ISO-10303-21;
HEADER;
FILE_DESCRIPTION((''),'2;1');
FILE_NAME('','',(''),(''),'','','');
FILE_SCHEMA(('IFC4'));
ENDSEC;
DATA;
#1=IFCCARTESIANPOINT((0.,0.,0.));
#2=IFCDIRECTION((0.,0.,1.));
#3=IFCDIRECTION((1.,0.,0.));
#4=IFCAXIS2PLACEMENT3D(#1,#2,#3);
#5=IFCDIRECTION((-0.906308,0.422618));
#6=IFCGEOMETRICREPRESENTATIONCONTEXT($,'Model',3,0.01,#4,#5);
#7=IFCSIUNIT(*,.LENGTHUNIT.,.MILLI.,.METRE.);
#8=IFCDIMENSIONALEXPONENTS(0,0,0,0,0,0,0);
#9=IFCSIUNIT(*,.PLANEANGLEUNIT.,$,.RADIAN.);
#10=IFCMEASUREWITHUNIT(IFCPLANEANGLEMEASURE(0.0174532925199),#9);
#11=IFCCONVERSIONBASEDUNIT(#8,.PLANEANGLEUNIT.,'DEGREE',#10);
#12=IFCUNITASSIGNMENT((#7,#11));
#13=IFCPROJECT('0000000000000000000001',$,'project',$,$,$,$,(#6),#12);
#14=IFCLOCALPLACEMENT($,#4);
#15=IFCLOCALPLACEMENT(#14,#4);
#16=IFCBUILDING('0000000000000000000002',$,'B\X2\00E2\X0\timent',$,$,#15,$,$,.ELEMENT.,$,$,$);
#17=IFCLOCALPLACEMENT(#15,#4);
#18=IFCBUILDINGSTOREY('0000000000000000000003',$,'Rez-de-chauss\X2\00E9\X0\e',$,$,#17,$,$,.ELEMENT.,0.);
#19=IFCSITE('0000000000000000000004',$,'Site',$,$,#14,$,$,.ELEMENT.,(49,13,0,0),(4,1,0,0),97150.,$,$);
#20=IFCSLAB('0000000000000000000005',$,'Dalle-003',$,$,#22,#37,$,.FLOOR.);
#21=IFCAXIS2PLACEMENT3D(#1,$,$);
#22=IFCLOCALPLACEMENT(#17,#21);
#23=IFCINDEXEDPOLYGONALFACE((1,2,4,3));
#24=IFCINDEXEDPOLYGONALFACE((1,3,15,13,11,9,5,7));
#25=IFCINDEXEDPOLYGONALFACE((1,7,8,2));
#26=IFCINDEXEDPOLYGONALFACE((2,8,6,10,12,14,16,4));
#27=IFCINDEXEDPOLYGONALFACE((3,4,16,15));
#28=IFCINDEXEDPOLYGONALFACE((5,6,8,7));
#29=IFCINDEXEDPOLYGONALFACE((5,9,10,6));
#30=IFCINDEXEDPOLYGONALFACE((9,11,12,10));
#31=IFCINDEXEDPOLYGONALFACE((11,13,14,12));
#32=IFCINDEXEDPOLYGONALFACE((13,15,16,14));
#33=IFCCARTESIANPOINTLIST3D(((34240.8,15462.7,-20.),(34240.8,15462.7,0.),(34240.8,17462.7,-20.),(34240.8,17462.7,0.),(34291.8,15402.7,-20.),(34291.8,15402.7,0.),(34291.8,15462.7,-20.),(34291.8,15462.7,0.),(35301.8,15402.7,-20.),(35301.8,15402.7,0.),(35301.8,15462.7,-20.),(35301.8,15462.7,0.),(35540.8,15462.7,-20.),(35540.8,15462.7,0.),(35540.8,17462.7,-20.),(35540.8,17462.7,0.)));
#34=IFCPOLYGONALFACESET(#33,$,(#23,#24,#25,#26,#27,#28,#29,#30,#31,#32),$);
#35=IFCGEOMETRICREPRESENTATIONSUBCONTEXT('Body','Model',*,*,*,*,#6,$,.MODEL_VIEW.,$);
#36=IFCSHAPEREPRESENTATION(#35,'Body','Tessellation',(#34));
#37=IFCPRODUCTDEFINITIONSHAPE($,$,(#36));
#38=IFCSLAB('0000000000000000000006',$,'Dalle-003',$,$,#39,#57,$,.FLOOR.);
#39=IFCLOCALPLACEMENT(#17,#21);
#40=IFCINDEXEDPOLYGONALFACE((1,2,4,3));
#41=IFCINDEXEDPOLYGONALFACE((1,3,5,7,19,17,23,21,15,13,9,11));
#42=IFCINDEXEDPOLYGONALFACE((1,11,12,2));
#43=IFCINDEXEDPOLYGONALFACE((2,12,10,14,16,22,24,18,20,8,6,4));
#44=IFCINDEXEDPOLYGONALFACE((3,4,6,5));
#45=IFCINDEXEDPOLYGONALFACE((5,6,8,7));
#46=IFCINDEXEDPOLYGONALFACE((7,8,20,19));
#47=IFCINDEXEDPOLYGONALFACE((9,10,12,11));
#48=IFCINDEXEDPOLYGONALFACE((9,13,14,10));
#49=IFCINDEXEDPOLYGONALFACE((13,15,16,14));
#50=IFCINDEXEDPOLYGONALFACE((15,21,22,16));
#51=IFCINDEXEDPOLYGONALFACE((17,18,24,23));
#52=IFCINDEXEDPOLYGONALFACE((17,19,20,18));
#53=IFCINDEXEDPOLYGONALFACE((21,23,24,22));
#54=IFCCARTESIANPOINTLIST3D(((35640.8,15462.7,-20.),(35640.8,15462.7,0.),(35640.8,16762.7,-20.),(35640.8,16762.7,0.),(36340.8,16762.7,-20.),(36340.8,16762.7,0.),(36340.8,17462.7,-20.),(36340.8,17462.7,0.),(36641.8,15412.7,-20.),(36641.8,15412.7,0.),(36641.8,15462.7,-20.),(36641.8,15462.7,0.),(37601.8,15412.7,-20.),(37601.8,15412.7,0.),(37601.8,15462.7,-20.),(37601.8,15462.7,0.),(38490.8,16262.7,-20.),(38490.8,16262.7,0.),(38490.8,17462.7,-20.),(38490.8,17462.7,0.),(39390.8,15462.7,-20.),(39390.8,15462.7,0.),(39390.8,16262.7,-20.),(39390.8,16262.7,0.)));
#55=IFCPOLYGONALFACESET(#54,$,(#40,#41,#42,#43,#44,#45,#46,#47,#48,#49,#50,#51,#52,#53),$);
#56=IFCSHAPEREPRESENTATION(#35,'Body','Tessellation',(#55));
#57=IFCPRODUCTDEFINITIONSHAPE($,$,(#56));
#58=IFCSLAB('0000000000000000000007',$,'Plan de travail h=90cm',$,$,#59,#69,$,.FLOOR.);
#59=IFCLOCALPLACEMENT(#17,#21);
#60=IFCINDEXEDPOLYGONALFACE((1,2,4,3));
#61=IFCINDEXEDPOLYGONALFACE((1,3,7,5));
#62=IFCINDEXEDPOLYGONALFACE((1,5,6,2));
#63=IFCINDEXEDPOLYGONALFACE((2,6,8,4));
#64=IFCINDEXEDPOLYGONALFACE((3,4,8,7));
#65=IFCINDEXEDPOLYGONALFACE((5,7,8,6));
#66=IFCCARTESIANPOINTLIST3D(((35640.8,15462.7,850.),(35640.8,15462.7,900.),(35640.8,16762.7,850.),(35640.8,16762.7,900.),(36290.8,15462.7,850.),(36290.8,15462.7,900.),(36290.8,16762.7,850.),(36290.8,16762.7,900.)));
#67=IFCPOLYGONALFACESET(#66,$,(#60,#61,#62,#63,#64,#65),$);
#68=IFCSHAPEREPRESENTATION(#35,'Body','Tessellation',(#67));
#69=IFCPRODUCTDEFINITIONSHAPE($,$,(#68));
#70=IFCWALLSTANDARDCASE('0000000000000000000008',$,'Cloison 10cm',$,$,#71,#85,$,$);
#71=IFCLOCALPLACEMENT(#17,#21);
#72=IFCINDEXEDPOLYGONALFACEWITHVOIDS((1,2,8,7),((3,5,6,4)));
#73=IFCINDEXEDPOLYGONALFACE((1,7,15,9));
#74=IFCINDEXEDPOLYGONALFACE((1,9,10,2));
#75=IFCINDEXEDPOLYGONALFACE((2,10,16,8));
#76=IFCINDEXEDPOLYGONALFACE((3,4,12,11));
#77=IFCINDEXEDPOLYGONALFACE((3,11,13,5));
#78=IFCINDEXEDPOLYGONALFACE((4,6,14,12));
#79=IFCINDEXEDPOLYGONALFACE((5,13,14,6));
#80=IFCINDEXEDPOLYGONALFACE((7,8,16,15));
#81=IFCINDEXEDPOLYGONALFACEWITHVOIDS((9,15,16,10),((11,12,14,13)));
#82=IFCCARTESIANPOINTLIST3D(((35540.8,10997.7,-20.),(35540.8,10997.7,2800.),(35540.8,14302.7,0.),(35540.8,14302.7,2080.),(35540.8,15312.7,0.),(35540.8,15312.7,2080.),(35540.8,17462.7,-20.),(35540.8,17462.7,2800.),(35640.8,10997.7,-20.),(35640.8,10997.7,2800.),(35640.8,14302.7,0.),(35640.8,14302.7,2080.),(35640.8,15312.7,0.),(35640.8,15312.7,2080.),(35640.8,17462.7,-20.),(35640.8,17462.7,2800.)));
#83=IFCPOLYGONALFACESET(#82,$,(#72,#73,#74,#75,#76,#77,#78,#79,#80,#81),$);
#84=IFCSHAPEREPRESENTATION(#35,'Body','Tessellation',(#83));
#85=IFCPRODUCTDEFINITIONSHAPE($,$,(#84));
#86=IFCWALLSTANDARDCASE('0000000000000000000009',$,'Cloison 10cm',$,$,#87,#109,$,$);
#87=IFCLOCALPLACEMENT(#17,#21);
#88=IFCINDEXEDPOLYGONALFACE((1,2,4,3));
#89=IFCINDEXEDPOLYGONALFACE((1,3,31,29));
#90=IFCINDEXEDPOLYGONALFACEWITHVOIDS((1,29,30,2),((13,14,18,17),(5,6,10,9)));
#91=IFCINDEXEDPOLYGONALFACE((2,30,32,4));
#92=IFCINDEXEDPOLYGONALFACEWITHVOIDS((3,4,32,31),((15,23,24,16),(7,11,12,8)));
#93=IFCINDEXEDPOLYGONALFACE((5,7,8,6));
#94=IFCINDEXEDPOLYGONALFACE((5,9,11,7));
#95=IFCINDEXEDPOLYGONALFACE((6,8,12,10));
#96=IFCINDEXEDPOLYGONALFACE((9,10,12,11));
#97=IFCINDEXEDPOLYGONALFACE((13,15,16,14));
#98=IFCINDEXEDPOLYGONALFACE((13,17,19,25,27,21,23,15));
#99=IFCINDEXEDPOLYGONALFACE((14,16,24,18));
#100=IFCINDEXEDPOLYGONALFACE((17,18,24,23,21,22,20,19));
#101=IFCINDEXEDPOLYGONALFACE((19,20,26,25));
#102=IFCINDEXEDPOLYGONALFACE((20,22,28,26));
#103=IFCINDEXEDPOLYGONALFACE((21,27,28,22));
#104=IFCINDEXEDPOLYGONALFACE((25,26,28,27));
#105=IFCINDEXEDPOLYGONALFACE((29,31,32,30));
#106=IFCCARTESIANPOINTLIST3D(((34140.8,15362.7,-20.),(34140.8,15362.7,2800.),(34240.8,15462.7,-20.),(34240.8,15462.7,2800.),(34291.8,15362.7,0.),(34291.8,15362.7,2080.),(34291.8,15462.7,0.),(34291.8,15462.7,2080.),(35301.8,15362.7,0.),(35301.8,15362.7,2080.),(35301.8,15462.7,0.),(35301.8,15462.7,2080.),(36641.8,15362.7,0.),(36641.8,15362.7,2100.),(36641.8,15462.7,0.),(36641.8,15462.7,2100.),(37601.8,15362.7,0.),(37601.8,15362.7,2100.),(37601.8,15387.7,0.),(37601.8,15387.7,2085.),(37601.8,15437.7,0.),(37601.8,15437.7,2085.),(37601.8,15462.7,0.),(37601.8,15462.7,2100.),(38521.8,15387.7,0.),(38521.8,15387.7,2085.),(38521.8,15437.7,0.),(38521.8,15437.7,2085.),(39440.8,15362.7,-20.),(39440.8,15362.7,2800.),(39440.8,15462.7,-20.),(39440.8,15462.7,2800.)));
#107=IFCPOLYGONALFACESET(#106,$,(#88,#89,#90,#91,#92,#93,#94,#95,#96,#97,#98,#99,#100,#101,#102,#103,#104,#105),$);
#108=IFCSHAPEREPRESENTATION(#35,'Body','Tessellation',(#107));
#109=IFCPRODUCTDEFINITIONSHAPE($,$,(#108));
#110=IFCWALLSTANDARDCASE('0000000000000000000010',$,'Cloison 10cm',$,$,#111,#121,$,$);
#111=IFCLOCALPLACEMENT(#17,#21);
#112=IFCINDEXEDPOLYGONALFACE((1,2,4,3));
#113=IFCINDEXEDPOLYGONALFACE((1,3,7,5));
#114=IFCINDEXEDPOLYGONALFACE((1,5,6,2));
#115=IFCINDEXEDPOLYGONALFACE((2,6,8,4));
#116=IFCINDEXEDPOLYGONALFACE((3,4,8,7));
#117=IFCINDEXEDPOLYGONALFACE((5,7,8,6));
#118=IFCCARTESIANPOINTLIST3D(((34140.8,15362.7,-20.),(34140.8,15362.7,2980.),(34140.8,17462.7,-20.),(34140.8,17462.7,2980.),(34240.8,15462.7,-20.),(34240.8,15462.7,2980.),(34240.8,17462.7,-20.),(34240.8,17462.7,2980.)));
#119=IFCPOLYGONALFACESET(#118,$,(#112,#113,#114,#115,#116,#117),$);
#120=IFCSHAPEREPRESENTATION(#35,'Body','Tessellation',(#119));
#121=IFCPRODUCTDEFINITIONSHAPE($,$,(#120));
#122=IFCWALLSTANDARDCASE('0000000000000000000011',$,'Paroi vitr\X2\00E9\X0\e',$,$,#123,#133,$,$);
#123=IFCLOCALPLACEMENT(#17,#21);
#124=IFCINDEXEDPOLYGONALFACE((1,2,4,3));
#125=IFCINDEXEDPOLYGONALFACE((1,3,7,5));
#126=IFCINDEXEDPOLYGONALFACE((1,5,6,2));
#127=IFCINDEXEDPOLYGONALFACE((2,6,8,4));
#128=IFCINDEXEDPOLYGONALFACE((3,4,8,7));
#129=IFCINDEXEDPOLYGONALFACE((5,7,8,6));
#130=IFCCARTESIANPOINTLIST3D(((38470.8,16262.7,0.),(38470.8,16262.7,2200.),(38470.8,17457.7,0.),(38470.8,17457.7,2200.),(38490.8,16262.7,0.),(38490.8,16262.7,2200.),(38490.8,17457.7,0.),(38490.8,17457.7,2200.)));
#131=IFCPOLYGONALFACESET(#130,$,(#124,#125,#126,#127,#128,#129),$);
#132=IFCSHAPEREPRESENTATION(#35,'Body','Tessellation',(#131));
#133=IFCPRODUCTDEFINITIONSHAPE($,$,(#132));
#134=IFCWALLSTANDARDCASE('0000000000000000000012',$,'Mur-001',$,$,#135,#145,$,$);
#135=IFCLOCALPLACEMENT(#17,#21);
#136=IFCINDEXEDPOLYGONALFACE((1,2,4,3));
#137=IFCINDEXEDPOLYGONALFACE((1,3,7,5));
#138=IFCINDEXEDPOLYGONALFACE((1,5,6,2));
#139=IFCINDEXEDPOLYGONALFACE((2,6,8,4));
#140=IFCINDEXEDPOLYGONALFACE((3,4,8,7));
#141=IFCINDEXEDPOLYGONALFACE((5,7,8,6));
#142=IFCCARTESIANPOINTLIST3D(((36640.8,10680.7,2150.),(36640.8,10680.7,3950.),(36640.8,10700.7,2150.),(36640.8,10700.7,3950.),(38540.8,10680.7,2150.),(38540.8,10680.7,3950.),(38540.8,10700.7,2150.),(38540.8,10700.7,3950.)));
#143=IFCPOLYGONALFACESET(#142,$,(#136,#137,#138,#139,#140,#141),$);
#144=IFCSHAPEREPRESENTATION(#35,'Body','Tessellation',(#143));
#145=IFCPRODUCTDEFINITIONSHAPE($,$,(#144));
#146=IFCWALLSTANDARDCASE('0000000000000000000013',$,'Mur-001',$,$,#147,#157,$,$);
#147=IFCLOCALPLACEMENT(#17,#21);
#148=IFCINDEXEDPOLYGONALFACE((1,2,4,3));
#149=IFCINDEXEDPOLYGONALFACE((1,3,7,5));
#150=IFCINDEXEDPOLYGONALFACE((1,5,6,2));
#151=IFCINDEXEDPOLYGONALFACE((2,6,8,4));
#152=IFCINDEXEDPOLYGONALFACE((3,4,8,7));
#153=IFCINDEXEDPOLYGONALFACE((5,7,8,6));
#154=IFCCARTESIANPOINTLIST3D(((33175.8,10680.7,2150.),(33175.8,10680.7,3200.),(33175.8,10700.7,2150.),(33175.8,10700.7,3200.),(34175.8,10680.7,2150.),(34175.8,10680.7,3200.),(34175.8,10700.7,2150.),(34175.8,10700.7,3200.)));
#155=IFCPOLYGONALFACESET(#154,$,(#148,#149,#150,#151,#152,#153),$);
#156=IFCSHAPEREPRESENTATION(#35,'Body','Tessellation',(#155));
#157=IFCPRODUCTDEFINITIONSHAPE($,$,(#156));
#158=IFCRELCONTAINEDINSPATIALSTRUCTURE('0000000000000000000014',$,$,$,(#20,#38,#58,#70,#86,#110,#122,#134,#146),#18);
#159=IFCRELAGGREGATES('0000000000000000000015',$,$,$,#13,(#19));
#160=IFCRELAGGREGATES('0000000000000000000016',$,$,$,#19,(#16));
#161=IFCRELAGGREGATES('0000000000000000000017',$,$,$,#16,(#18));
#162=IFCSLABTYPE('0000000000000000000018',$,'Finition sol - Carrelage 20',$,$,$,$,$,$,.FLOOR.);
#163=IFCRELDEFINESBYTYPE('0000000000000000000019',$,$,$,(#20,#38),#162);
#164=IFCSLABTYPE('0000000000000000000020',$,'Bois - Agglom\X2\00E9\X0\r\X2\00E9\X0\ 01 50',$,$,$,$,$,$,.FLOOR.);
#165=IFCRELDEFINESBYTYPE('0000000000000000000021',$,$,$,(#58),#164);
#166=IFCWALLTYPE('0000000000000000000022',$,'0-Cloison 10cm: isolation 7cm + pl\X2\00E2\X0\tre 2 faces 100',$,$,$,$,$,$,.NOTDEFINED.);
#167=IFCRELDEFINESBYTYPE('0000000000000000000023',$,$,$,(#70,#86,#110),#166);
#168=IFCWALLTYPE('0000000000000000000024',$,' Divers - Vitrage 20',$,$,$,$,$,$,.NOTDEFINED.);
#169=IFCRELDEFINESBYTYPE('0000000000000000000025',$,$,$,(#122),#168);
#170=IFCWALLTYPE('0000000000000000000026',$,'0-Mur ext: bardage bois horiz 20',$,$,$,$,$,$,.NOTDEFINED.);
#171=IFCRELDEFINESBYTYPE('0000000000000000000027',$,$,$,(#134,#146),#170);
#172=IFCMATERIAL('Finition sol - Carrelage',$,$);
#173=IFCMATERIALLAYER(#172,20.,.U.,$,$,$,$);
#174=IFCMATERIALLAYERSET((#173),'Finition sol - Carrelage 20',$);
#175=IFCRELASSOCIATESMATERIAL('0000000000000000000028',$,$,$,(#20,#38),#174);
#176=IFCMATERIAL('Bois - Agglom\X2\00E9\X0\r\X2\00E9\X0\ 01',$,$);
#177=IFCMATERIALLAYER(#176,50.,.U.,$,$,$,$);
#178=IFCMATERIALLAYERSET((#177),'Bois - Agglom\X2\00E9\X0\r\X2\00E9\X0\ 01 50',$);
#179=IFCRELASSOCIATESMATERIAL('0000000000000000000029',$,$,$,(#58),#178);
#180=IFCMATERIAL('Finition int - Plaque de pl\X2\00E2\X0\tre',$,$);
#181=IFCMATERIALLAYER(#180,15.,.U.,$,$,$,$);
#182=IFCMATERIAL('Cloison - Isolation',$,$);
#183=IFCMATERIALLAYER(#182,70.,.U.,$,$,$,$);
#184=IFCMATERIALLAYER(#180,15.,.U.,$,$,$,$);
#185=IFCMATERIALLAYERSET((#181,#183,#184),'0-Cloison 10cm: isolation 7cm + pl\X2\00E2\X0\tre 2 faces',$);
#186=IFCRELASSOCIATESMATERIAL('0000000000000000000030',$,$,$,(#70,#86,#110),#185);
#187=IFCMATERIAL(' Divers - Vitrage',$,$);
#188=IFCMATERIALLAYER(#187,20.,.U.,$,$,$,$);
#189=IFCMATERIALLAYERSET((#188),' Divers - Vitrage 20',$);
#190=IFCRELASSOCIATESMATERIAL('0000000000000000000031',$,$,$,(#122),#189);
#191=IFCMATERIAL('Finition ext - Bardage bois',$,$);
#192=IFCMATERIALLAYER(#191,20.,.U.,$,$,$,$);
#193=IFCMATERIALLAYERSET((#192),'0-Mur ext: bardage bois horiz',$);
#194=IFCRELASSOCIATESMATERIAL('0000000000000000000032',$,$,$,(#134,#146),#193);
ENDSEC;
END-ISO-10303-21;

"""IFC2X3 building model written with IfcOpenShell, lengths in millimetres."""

from ifc_helpers import new_model, entity, si_unit, converted_unit, direction, frame, origin_with_axes, origin_2d_with_axis, place, context, subcontext, project, spatial, polyline, rectangle, outline, extrude, material, layer, layer_set, layer_usage, type_object, element, save


model = new_model("IFC2X3")

# Units and contexts
model_context = context("Model", 3, precision=0.01, world=origin_with_axes(), true_north=direction((-0.906308, 0.422618)))
body_context = subcontext(model_context, "Body", "Model", "MODEL_VIEW")
ifc_project = project(units=[si_unit("LENGTHUNIT", "METRE", prefix="MILLI"), converted_unit("PLANEANGLEUNIT", "DEGREE", entity("IfcPlaneAngleMeasure", 0.0174532925199), si_unit("PLANEANGLEUNIT", "RADIAN"), dimensions=[0, 0, 0, 0, 0, 0, 0])], contexts=[model_context])

# Site, building, storey
site_placement = place(None, origin_with_axes())
site = spatial("IfcSite", under=ifc_project, at=site_placement, Name="Site", CompositionType="ELEMENT", RefLatitude=(49, 13, 0, 0), RefLongitude=(4, 1, 0, 0), RefElevation=97150.0)
building_placement = place(site_placement, origin_with_axes())
building = spatial("IfcBuilding", under=site, at=building_placement, Name="Bâtiment", CompositionType="ELEMENT")
storey_placement = place(building_placement, origin_with_axes())
storey = spatial("IfcBuildingStorey", under=building, at=storey_placement, Name="Rez-de-chaussée", CompositionType="ELEMENT", Elevation=0.0)

# Slabs
ifc_material_1 = material(Name="Finition sol - Carrelage")
ifc_layer_1 = layer(ifc_material_1, 20.0, ventilated="UNKNOWN")
ifc_layer_set_1 = layer_set([ifc_layer_1], Name="Finition sol - Carrelage 20")
ifc_layer_usage_1 = layer_usage(ifc_layer_set_1, "AXIS3", "NEGATIVE", 20.0)
slab_type_1 = type_object("IfcSlabType", Name="Finition sol - Carrelage 20", PredefinedType="FLOOR")
slab_1_placement = place(storey_placement, frame((34240.8, 15462.7, 0.0), z_axis=(0.0, 0.0, 1.0), x_axis=(1.0, 0.0, 0.0)))
element("IfcSlab", 1, at=slab_1_placement, inside=storey, type_object=slab_type_1, material=ifc_layer_usage_1, Name="Dalle-003", PredefinedType="FLOOR", context=body_context, shape_type="SweptSolid", body=[
    extrude(outline(polyline([(0.0, 0.0), (51.0, 0.0), (51.0, -60.0), (1061.0, -60.0), (1061.0, 0.0), (1300.0, 0.0), (1300.0, 2000.0), (0.0, 2000.0), (0.0, 0.0)])), frame((0.0, 0.0, -20.0), z_axis=(0.0, 0.0, 1.0), x_axis=(1.0, 0.0, 0.0)), (0.0, 0.0, 1.0), 20.0),
])
ifc_layer_usage_2 = layer_usage(ifc_layer_set_1, "AXIS3", "NEGATIVE", 20.0)
slab_2_placement = place(storey_placement, frame((35640.8, 15462.7, 0.0), z_axis=(0.0, 0.0, 1.0), x_axis=(1.0, 0.0, 0.0)))
element("IfcSlab", 2, at=slab_2_placement, inside=storey, type_object=slab_type_1, material=ifc_layer_usage_2, Name="Dalle-003", PredefinedType="FLOOR", context=body_context, shape_type="SweptSolid", body=[
    extrude(outline(polyline([(0.0, 0.0), (1001.0, 0.0), (1001.0, -50.0), (1961.0, -50.0), (1961.0, 0.0), (3750.0, 0.0), (3750.0, 800.0), (2850.0, 800.0), (2850.0, 2000.0), (700.0, 2000.0), (700.0, 1300.0), (0.0, 1300.0), (0.0, 0.0)])), frame((0.0, 0.0, -20.0), z_axis=(0.0, 0.0, 1.0), x_axis=(1.0, 0.0, 0.0)), (0.0, 0.0, 1.0), 20.0),
])
ifc_material_2 = material(Name="Bois - Aggloméré 01")
ifc_layer_2 = layer(ifc_material_2, 50.0, ventilated="UNKNOWN")
ifc_layer_set_2 = layer_set([ifc_layer_2], Name="Bois - Aggloméré 01 50")
ifc_layer_usage_3 = layer_usage(ifc_layer_set_2, "AXIS3", "NEGATIVE", 50.0)
slab_type_2 = type_object("IfcSlabType", Name="Bois - Aggloméré 01 50", PredefinedType="FLOOR")
slab_3_placement = place(storey_placement, frame((35640.8, 15462.7, 900.0), z_axis=(0.0, 0.0, 1.0), x_axis=(1.0, 0.0, 0.0)))
element("IfcSlab", 3, at=slab_3_placement, inside=storey, type_object=slab_type_2, material=ifc_layer_usage_3, Name="Plan de travail h=90cm", PredefinedType="FLOOR", context=body_context, shape_type="SweptSolid", body=[
    extrude(outline(polyline([(0.0, 0.0), (650.0, 0.0), (650.0, 1300.0), (0.0, 1300.0), (0.0, 0.0)])), frame((0.0, 0.0, -50.0), z_axis=(0.0, 0.0, 1.0), x_axis=(1.0, 0.0, 0.0)), (0.0, 0.0, 1.0), 50.0),
])

# Wall, opening
ifc_material_3 = material(Name="Finition int - Plaque de plâtre")
ifc_layer_3 = layer(ifc_material_3, 15.0, ventilated="UNKNOWN")
ifc_material_4 = material(Name="Cloison - Isolation")
ifc_layer_4 = layer(ifc_material_4, 70.0, ventilated="UNKNOWN")
ifc_layer_5 = layer(ifc_material_3, 15.0, ventilated="UNKNOWN")
ifc_layer_set_3 = layer_set([ifc_layer_3, ifc_layer_4, ifc_layer_5], Name="0-Cloison 10cm: isolation 7cm + plâtre 2 faces")
ifc_layer_usage_4 = layer_usage(ifc_layer_set_3, "AXIS2", "POSITIVE", 0.0)
wall_type_1 = type_object("IfcWallType", Name="0-Cloison 10cm: isolation 7cm + plâtre 2 faces 100", PredefinedType="NOTDEFINED")
wall_1_placement = place(storey_placement, frame((35540.8, 17462.7, -20.0), z_axis=(0.0, 0.0, 1.0), x_axis=(0.0, -1.0, 0.0)))
wall_1 = element("IfcWallStandardCase", 4, at=wall_1_placement, inside=storey, type_object=wall_type_1, material=ifc_layer_usage_4, Name="Cloison 10cm", context=body_context, shape_type="SweptSolid", body=[
    extrude(outline(polyline([(0.0, 0.0), (6465.0, 0.0), (6465.0, 100.0), (0.0, 100.0), (0.0, 0.0)])), origin_with_axes(), (0.0, 0.0, 1.0), 2820.0),
])
opening_1_placement = place(wall_1_placement, frame((2655.0, 0.0, 20.0), z_axis=(0.0, 0.0, 1.0), x_axis=(1.0, 0.0, 0.0)))
element("IfcOpeningElement", 5, at=opening_1_placement, cuts=wall_1, context=body_context, shape_type="SweptSolid", body=[
    extrude(rectangle(XDim=1010.0, YDim=2080.0, at=origin_2d_with_axis()), frame((0.0, -100.0, 1040.0), z_axis=(0.0, -1.0, 0.0), x_axis=(-1.0, 0.0, 0.0)), (0.0, 0.0, -1.0), 300.0),
])

# Wall, openings
ifc_layer_usage_5 = layer_usage(ifc_layer_set_3, "AXIS2", "POSITIVE", 0.0)
wall_2_placement = place(storey_placement, frame((34140.8, 15362.7, -20.0), z_axis=(0.0, 0.0, 1.0), x_axis=(1.0, 0.0, 0.0)))
wall_2 = element("IfcWallStandardCase", 6, at=wall_2_placement, inside=storey, type_object=wall_type_1, material=ifc_layer_usage_5, Name="Cloison 10cm", context=body_context, shape_type="SweptSolid", body=[
    extrude(outline(polyline([(0.0, 0.0), (5300.0, 0.0), (5300.0, 100.0), (100.0, 100.0), (0.0, 0.0)])), origin_with_axes(), (0.0, 0.0, 1.0), 2820.0),
])
opening_2_placement = place(wall_2_placement, frame((2981.0, 0.0, 20.0), z_axis=(0.0, 0.0, 1.0), x_axis=(1.0, 0.0, 0.0)))
element("IfcOpeningElement", 7, at=opening_2_placement, cuts=wall_2, context=body_context, shape_type="SweptSolid", body=[
    extrude(rectangle(XDim=960.0, YDim=2100.0, at=origin_2d_with_axis()), frame((0.0, -100.0, 1050.0), z_axis=(0.0, 1.0, 0.0), x_axis=(1.0, 0.0, 0.0)), (0.0, 0.0, 1.0), 300.0),
    extrude(outline(polyline([(1400.0, 0.0), (1400.0, 2085.0), (480.0, 2085.0), (480.0, 0.0), (1400.0, 0.0)])), frame((0.0, 75.0, 0.0), z_axis=(0.0, -1.0, 0.0), x_axis=(1.0, 0.0, 0.0)), (0.0, 0.0, 1.0), 50.0),
])
opening_3_placement = place(wall_2_placement, frame((656.0, 0.0, 20.0), z_axis=(0.0, 0.0, 1.0), x_axis=(1.0, 0.0, 0.0)))
element("IfcOpeningElement", 8, at=opening_3_placement, cuts=wall_2, context=body_context, shape_type="SweptSolid", body=[
    extrude(rectangle(XDim=1010.0, YDim=2080.0, at=origin_2d_with_axis()), frame((0.0, 100.0, 1040.0), z_axis=(0.0, 1.0, 0.0), x_axis=(1.0, 0.0, 0.0)), (0.0, 0.0, -1.0), 300.0),
])

# Walls
ifc_layer_usage_6 = layer_usage(ifc_layer_set_3, "AXIS2", "POSITIVE", -100.0)
wall_3_placement = place(storey_placement, frame((34140.8, 15362.7, -20.0), z_axis=(0.0, 0.0, 1.0), x_axis=(0.0, 1.0, 0.0)))
element("IfcWallStandardCase", 9, at=wall_3_placement, inside=storey, type_object=wall_type_1, material=ifc_layer_usage_6, Name="Cloison 10cm", context=body_context, shape_type="SweptSolid", body=[
    extrude(outline(polyline([(100.0, -100.0), (2100.0, -100.0), (2100.0, 0.0), (0.0, 0.0), (100.0, -100.0)])), origin_with_axes(), (0.0, 0.0, 1.0), 3000.0),
])
ifc_material_5 = material(Name=" Divers - Vitrage")
ifc_layer_6 = layer(ifc_material_5, 20.0, ventilated="UNKNOWN")
ifc_layer_set_4 = layer_set([ifc_layer_6], Name=" Divers - Vitrage 20")
ifc_layer_usage_7 = layer_usage(ifc_layer_set_4, "AXIS2", "POSITIVE", -20.0)
wall_type_2 = type_object("IfcWallType", Name=" Divers - Vitrage 20", PredefinedType="NOTDEFINED")
wall_4_placement = place(storey_placement, frame((38490.8, 17457.7, 0.0), z_axis=(0.0, 0.0, 1.0), x_axis=(0.0, -1.0, 0.0)))
element("IfcWallStandardCase", 10, at=wall_4_placement, inside=storey, type_object=wall_type_2, material=ifc_layer_usage_7, Name="Paroi vitrée", context=body_context, shape_type="SweptSolid", body=[
    extrude(outline(polyline([(0.0, -20.0), (1195.0, -20.0), (1195.0, 0.0), (0.0, 0.0), (0.0, -20.0)])), origin_with_axes(), (0.0, 0.0, 1.0), 2200.0),
])
ifc_material_6 = material(Name="Finition ext - Bardage bois")
ifc_layer_7 = layer(ifc_material_6, 20.0, ventilated="UNKNOWN")
ifc_layer_set_5 = layer_set([ifc_layer_7], Name="0-Mur ext: bardage bois horiz")
ifc_layer_usage_8 = layer_usage(ifc_layer_set_5, "AXIS2", "POSITIVE", 0.0)
wall_type_3 = type_object("IfcWallType", Name="0-Mur ext: bardage bois horiz 20", PredefinedType="NOTDEFINED")
wall_5_placement = place(storey_placement, frame((36640.8, 10680.7, 2150.0), z_axis=(0.0, 0.0, 1.0), x_axis=(1.0, 0.0, 0.0)))
element("IfcWallStandardCase", 11, at=wall_5_placement, inside=storey, type_object=wall_type_3, material=ifc_layer_usage_8, Name="Mur-001", context=body_context, shape_type="SweptSolid", body=[
    extrude(outline(polyline([(0.0, 0.0), (1900.0, 0.0), (1900.0, 20.0), (0.0, 20.0), (0.0, 0.0)])), origin_with_axes(), (0.0, 0.0, 1.0), 1800.0),
])
ifc_layer_usage_9 = layer_usage(ifc_layer_set_5, "AXIS2", "POSITIVE", 0.0)
wall_6_placement = place(storey_placement, frame((33175.8, 10680.7, 2150.0), z_axis=(0.0, 0.0, 1.0), x_axis=(1.0, 0.0, 0.0)))
element("IfcWallStandardCase", 12, at=wall_6_placement, inside=storey, type_object=wall_type_3, material=ifc_layer_usage_9, Name="Mur-001", context=body_context, shape_type="SweptSolid", body=[
    extrude(outline(polyline([(0.0, 0.0), (1000.0, 0.0), (1000.0, 20.0), (0.0, 20.0), (0.0, 0.0)])), origin_with_axes(), (0.0, 0.0, 1.0), 1050.0),
])

save(model, "model.ifc")
